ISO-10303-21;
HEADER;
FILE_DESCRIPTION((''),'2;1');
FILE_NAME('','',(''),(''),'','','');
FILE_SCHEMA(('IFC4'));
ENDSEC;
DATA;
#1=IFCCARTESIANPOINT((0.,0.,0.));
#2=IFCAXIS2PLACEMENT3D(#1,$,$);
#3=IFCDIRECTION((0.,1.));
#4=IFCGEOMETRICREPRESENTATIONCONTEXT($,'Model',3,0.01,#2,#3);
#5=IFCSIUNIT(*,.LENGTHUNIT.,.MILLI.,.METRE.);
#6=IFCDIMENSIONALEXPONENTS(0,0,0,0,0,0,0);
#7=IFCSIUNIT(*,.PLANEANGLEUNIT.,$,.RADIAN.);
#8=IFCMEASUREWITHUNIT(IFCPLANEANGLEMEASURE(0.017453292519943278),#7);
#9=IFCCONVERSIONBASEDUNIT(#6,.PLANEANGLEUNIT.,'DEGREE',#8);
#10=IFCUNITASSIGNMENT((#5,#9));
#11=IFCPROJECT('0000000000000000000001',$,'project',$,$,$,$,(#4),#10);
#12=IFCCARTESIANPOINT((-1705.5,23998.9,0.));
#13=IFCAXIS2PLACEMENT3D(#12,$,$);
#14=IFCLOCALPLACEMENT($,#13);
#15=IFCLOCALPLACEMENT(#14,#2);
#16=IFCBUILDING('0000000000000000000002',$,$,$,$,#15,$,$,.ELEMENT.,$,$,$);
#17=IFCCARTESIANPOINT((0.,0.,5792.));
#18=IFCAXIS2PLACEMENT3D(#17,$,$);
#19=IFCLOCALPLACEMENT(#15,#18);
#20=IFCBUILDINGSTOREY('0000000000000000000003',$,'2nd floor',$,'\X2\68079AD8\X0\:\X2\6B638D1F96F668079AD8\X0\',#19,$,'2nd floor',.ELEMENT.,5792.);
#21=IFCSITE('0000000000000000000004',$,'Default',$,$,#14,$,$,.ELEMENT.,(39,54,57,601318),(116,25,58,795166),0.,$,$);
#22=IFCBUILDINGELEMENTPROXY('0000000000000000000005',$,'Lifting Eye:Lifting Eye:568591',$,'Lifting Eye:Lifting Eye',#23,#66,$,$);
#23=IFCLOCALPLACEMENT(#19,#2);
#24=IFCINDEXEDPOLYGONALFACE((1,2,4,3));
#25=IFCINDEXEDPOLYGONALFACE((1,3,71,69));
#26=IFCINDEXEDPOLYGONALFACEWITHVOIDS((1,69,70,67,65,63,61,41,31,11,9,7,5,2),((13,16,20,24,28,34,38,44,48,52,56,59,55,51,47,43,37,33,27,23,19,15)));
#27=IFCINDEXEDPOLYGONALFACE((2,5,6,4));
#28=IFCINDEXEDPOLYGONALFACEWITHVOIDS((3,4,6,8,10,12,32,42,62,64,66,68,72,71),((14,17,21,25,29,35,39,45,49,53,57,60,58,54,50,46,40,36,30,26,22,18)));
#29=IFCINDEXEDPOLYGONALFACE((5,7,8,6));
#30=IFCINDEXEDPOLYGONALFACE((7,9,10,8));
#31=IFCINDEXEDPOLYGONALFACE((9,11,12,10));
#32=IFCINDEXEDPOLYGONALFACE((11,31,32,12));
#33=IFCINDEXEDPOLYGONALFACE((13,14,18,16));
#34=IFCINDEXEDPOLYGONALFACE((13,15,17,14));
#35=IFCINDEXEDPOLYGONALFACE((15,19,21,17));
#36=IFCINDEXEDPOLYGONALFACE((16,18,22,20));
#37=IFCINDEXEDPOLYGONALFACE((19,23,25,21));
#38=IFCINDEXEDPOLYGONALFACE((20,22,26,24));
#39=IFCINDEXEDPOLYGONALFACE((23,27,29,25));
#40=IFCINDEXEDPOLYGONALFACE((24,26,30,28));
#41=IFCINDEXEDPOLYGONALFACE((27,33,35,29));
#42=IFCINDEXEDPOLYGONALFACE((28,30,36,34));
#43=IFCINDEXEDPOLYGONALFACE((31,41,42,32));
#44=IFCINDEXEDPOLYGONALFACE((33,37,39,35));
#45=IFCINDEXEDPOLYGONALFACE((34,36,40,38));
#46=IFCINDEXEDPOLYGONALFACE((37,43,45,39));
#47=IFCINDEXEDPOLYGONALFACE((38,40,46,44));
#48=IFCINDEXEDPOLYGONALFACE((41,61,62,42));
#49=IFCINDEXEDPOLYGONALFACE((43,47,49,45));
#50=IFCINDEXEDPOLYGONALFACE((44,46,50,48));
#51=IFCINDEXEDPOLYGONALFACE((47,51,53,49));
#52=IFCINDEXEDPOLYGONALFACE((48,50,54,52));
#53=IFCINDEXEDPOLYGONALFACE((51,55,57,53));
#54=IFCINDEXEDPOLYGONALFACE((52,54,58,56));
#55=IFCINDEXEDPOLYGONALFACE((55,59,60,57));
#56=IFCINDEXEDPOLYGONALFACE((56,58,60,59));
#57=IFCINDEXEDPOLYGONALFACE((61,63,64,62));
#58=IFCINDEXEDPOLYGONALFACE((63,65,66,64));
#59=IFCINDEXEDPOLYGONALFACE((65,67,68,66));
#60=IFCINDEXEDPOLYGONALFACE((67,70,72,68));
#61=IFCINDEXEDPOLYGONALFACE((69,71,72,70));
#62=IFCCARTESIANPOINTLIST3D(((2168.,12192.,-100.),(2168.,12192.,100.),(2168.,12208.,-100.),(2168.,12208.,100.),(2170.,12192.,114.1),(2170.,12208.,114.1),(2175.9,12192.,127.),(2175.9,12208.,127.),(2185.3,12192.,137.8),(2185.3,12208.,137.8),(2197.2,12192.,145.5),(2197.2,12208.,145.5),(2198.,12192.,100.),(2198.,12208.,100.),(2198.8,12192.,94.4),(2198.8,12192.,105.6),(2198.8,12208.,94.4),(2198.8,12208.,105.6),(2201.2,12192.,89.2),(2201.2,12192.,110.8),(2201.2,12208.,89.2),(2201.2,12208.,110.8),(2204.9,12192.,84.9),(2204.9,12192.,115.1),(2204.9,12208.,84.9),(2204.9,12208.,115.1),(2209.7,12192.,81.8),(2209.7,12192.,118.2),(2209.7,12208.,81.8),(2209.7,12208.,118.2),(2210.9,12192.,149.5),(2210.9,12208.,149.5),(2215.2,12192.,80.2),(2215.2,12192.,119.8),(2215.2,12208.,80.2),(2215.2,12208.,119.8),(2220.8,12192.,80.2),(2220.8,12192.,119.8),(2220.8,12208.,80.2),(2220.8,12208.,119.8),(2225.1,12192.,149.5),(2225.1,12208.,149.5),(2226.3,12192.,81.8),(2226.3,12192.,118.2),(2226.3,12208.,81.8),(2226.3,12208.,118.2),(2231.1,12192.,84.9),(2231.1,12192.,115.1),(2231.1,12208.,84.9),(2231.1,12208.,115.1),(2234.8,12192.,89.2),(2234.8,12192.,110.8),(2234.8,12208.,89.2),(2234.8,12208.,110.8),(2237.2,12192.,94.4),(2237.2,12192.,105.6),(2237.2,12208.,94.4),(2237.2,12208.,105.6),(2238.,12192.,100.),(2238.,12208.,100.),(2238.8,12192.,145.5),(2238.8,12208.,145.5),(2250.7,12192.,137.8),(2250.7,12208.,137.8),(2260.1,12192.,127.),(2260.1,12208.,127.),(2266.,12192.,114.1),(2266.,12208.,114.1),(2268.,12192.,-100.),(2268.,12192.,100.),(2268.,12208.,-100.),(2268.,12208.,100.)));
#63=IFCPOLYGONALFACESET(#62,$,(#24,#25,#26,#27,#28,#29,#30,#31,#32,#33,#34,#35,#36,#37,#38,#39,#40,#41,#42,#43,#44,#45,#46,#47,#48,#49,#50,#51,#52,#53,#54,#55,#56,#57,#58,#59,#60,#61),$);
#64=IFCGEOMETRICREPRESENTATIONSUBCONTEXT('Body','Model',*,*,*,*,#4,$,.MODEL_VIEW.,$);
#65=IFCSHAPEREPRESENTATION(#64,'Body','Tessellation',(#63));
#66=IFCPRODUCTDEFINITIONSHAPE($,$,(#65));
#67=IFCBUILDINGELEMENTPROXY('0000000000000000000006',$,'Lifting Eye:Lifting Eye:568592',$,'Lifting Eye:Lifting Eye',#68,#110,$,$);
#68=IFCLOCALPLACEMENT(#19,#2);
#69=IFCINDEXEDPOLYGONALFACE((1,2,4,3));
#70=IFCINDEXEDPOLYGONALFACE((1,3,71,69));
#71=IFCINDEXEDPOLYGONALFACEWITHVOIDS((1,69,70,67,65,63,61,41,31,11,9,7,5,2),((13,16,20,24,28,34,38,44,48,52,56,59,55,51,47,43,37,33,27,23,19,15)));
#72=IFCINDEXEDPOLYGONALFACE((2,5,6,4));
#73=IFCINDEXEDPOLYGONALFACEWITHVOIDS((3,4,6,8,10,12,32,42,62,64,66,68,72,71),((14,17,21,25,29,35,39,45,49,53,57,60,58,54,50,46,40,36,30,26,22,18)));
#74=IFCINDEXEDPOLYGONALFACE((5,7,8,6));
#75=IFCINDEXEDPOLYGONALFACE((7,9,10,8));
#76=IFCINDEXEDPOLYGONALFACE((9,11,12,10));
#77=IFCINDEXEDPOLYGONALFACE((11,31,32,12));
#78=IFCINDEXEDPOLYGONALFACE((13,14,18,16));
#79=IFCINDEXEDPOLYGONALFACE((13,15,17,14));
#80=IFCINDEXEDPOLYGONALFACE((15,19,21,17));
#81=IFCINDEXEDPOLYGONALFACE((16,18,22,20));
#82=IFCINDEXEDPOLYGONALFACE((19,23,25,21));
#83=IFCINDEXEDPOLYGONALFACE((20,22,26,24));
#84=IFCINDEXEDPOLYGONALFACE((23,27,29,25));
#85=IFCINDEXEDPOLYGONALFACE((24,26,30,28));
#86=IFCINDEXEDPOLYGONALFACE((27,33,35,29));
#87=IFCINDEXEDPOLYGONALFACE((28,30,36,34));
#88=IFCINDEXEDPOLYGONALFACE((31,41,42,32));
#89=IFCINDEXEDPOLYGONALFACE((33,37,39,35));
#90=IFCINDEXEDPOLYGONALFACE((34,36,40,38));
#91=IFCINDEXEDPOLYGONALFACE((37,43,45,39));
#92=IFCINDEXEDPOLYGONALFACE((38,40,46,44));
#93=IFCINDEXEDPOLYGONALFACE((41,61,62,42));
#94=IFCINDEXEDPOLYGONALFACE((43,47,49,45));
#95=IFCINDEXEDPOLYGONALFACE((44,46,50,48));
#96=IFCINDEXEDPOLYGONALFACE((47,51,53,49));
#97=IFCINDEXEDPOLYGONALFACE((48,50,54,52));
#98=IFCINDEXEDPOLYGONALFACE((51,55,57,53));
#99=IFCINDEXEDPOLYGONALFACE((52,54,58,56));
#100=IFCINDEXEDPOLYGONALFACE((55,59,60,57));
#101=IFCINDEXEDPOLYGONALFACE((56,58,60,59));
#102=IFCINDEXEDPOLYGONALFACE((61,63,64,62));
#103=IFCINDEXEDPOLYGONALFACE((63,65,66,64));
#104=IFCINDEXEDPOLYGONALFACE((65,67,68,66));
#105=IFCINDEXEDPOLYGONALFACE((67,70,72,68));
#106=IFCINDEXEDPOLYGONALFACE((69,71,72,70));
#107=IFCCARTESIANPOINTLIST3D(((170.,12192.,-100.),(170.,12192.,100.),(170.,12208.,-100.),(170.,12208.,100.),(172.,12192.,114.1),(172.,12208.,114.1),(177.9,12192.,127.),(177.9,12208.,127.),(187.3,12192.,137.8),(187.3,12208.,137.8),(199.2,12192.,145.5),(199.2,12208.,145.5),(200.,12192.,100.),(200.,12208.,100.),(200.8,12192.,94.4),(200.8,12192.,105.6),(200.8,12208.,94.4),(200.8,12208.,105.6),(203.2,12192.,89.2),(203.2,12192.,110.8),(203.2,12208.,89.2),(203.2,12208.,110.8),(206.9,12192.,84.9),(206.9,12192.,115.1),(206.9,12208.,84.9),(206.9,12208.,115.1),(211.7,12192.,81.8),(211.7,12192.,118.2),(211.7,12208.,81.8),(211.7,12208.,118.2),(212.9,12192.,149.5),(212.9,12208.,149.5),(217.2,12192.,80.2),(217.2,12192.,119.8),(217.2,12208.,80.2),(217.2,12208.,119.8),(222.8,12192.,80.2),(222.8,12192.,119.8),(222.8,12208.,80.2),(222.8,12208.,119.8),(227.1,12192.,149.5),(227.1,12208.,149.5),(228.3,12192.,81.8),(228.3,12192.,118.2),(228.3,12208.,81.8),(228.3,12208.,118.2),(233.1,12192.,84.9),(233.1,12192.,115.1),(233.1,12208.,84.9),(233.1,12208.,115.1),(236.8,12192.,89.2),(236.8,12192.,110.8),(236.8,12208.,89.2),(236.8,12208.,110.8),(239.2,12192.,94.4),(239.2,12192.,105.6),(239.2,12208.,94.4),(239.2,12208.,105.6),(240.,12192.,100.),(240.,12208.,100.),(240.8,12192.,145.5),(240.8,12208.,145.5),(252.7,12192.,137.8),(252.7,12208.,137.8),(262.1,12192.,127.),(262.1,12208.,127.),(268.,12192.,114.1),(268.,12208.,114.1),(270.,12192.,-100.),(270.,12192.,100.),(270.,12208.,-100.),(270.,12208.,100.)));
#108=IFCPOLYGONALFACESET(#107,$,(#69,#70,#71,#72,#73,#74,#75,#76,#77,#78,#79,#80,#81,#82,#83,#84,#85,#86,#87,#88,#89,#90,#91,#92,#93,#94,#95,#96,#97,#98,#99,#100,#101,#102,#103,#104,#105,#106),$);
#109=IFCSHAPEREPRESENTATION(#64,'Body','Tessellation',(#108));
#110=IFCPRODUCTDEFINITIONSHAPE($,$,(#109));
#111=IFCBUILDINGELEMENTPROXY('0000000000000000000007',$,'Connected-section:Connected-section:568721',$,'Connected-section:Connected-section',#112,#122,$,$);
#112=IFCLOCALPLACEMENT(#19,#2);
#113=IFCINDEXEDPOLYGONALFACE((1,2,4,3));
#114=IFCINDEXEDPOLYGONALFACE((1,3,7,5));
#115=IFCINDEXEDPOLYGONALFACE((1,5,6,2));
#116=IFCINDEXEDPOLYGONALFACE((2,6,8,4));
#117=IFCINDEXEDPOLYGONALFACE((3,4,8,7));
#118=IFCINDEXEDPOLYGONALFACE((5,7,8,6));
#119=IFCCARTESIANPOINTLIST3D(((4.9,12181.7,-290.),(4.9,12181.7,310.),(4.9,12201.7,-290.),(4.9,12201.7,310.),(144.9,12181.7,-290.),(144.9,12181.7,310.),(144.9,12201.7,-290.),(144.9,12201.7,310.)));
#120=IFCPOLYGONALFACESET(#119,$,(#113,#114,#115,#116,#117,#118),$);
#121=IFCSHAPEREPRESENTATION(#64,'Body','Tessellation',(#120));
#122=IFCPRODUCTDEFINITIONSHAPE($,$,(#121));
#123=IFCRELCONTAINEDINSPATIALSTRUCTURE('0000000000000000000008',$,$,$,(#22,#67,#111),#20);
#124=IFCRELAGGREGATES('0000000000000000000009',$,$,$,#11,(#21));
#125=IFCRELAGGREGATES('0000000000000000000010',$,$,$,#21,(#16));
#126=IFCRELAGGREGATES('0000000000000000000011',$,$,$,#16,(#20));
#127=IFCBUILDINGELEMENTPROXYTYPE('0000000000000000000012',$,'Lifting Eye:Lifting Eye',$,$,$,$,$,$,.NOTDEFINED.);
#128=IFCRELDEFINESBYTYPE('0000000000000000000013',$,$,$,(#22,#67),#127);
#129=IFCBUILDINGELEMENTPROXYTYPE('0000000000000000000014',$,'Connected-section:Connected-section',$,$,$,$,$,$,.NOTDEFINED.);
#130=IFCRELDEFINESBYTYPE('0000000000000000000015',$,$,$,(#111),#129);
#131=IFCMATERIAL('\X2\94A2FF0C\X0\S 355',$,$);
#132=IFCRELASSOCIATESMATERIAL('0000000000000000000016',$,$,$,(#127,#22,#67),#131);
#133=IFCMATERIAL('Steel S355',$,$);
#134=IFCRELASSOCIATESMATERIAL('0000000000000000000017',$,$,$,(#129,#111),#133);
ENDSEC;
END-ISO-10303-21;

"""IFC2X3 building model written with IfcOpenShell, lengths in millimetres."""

from ifc_helpers import new_model, entity, si_unit, converted_unit, direction, frame, frame_2d, origin, place, context, subcontext, project, spatial, polyline, circle_curve, parameter, trimmed, segment, composite_curve, rectangle, outline, extrude, source, transform, mapped, material, type_object, type_shapes, element, save


model = new_model("IFC2X3")

# Units and contexts
model_context = context("Model", 3, precision=0.01, world=origin(), true_north=direction((0.0, 1.0)))
body_context = subcontext(model_context, "Body", "Model", "MODEL_VIEW")
ifc_project = project(units=[si_unit("LENGTHUNIT", "METRE", prefix="MILLI"), converted_unit("PLANEANGLEUNIT", "DEGREE", entity("IfcPlaneAngleMeasure", 0.017453292519943278), si_unit("PLANEANGLEUNIT", "RADIAN"), dimensions=[0, 0, 0, 0, 0, 0, 0])], contexts=[model_context])

# Site, building, storey
site_placement = place(None, frame((-1705.5, 23998.9, 0.0)))
site = spatial("IfcSite", under=ifc_project, at=site_placement, Name="Default", CompositionType="ELEMENT", RefLatitude=(39, 54, 57, 601318), RefLongitude=(116, 25, 58, 795166), RefElevation=0.0)
building_placement = place(site_placement, origin())
building = spatial("IfcBuilding", under=site, at=building_placement, CompositionType="ELEMENT")
storey_placement = place(building_placement, frame((0.0, 0.0, 5792.0)))
storey = spatial("IfcBuildingStorey", under=building, at=storey_placement, Name="2nd floor", ObjectType="标高:正负零标高", LongName="2nd floor", CompositionType="ELEMENT", Elevation=5792.0)

# Shared definitions
ifc_material_1 = material(Name="Steel S355")

# Building element proxies
ifc_material_2 = material(Name="钢，S 355")
building_element_proxy_type_1 = type_object("IfcBuildingElementProxyType", Name="Lifting Eye:Lifting Eye", PredefinedType="NOTDEFINED", material=ifc_material_2)
shared_shape_1 = source(origin(), body_context, "Body", "SweptSolid", [
    extrude(outline(composite_curve([segment(polyline([(-100.0, -50.0), (100.0, -50.0)]), True, "CONTINUOUS"), segment(polyline([(100.0, -50.0), (100.0, 50.0)]), True, "CONTINUOUS"), segment(polyline([(100.0, 50.0), (-100.0, 50.0)]), True, "CONTINUOUS"), segment(trimmed(circle_curve(frame_2d((-100.0, 0.0), x_axis=(0.0, -1.0)), 50.0), [parameter(180.0)], [parameter(0.0)], True, "PARAMETER"), True, "CONTINUOUS")], self_intersect=False), holes=[composite_curve([segment(trimmed(circle_curve(frame_2d((-100.0, 0.0), x_axis=(0.0, -1.0)), 20.0), [parameter(180.0)], [parameter(360.0)], True, "PARAMETER"), False, "CONTINUOUS"), segment(trimmed(circle_curve(frame_2d((-100.0, 0.0), x_axis=(0.0, -1.0)), 20.0), [parameter(0.0)], [parameter(180.0)], True, "PARAMETER"), False, "CONTINUOUS")], self_intersect=False)]), frame((0.0, 17.0, -17.0), z_axis=(0.0, 1.0, 0.0), x_axis=(0.0, 0.0, -1.0)), (0.0, 0.0, 1.0), 16.0),
])
type_shapes(building_element_proxy_type_1, [shared_shape_1])
for number, where, name in (
    (1, (2218.0, 12175.0, 17.0), "Lifting Eye:Lifting Eye:568591"),
    (2, (220.0, 12175.0, 17.0), "Lifting Eye:Lifting Eye:568592"),
):
    element("IfcBuildingElementProxy", number, at=place(storey_placement, frame(where)), inside=storey, type_object=building_element_proxy_type_1, material=ifc_material_2, Name=name, ObjectType="Lifting Eye:Lifting Eye", context=body_context, shape_type="MappedRepresentation", body=[
        mapped(shared_shape_1, transform((0.0, 0.0, 0.0), scale=1.0)),
    ])
building_element_proxy_type_2 = type_object("IfcBuildingElementProxyType", Name="Connected-section:Connected-section", PredefinedType="NOTDEFINED", material=ifc_material_1)
shared_shape_2 = source(origin(), body_context, "Body", "SweptSolid", [
    extrude(rectangle(XDim=20.0, YDim=140.0, at=frame_2d((0.0, 0.0), x_axis=(1.0, 0.0))), frame((70.0, 10.0, 0.0), z_axis=(0.0, 0.0, 1.0), x_axis=(0.0, 1.0, 0.0)), (0.0, 0.0, 1.0), 600.0),
])
type_shapes(building_element_proxy_type_2, [shared_shape_2])
proxy_1_placement = place(storey_placement, frame((4.9, 12181.7, -290.0)))
element("IfcBuildingElementProxy", 3, at=proxy_1_placement, inside=storey, type_object=building_element_proxy_type_2, material=ifc_material_1, Name="Connected-section:Connected-section:568721", ObjectType="Connected-section:Connected-section", context=body_context, shape_type="MappedRepresentation", body=[
    mapped(shared_shape_2, transform((0.0, 0.0, 0.0), scale=1.0)),
])

save(model, "model.ifc")
